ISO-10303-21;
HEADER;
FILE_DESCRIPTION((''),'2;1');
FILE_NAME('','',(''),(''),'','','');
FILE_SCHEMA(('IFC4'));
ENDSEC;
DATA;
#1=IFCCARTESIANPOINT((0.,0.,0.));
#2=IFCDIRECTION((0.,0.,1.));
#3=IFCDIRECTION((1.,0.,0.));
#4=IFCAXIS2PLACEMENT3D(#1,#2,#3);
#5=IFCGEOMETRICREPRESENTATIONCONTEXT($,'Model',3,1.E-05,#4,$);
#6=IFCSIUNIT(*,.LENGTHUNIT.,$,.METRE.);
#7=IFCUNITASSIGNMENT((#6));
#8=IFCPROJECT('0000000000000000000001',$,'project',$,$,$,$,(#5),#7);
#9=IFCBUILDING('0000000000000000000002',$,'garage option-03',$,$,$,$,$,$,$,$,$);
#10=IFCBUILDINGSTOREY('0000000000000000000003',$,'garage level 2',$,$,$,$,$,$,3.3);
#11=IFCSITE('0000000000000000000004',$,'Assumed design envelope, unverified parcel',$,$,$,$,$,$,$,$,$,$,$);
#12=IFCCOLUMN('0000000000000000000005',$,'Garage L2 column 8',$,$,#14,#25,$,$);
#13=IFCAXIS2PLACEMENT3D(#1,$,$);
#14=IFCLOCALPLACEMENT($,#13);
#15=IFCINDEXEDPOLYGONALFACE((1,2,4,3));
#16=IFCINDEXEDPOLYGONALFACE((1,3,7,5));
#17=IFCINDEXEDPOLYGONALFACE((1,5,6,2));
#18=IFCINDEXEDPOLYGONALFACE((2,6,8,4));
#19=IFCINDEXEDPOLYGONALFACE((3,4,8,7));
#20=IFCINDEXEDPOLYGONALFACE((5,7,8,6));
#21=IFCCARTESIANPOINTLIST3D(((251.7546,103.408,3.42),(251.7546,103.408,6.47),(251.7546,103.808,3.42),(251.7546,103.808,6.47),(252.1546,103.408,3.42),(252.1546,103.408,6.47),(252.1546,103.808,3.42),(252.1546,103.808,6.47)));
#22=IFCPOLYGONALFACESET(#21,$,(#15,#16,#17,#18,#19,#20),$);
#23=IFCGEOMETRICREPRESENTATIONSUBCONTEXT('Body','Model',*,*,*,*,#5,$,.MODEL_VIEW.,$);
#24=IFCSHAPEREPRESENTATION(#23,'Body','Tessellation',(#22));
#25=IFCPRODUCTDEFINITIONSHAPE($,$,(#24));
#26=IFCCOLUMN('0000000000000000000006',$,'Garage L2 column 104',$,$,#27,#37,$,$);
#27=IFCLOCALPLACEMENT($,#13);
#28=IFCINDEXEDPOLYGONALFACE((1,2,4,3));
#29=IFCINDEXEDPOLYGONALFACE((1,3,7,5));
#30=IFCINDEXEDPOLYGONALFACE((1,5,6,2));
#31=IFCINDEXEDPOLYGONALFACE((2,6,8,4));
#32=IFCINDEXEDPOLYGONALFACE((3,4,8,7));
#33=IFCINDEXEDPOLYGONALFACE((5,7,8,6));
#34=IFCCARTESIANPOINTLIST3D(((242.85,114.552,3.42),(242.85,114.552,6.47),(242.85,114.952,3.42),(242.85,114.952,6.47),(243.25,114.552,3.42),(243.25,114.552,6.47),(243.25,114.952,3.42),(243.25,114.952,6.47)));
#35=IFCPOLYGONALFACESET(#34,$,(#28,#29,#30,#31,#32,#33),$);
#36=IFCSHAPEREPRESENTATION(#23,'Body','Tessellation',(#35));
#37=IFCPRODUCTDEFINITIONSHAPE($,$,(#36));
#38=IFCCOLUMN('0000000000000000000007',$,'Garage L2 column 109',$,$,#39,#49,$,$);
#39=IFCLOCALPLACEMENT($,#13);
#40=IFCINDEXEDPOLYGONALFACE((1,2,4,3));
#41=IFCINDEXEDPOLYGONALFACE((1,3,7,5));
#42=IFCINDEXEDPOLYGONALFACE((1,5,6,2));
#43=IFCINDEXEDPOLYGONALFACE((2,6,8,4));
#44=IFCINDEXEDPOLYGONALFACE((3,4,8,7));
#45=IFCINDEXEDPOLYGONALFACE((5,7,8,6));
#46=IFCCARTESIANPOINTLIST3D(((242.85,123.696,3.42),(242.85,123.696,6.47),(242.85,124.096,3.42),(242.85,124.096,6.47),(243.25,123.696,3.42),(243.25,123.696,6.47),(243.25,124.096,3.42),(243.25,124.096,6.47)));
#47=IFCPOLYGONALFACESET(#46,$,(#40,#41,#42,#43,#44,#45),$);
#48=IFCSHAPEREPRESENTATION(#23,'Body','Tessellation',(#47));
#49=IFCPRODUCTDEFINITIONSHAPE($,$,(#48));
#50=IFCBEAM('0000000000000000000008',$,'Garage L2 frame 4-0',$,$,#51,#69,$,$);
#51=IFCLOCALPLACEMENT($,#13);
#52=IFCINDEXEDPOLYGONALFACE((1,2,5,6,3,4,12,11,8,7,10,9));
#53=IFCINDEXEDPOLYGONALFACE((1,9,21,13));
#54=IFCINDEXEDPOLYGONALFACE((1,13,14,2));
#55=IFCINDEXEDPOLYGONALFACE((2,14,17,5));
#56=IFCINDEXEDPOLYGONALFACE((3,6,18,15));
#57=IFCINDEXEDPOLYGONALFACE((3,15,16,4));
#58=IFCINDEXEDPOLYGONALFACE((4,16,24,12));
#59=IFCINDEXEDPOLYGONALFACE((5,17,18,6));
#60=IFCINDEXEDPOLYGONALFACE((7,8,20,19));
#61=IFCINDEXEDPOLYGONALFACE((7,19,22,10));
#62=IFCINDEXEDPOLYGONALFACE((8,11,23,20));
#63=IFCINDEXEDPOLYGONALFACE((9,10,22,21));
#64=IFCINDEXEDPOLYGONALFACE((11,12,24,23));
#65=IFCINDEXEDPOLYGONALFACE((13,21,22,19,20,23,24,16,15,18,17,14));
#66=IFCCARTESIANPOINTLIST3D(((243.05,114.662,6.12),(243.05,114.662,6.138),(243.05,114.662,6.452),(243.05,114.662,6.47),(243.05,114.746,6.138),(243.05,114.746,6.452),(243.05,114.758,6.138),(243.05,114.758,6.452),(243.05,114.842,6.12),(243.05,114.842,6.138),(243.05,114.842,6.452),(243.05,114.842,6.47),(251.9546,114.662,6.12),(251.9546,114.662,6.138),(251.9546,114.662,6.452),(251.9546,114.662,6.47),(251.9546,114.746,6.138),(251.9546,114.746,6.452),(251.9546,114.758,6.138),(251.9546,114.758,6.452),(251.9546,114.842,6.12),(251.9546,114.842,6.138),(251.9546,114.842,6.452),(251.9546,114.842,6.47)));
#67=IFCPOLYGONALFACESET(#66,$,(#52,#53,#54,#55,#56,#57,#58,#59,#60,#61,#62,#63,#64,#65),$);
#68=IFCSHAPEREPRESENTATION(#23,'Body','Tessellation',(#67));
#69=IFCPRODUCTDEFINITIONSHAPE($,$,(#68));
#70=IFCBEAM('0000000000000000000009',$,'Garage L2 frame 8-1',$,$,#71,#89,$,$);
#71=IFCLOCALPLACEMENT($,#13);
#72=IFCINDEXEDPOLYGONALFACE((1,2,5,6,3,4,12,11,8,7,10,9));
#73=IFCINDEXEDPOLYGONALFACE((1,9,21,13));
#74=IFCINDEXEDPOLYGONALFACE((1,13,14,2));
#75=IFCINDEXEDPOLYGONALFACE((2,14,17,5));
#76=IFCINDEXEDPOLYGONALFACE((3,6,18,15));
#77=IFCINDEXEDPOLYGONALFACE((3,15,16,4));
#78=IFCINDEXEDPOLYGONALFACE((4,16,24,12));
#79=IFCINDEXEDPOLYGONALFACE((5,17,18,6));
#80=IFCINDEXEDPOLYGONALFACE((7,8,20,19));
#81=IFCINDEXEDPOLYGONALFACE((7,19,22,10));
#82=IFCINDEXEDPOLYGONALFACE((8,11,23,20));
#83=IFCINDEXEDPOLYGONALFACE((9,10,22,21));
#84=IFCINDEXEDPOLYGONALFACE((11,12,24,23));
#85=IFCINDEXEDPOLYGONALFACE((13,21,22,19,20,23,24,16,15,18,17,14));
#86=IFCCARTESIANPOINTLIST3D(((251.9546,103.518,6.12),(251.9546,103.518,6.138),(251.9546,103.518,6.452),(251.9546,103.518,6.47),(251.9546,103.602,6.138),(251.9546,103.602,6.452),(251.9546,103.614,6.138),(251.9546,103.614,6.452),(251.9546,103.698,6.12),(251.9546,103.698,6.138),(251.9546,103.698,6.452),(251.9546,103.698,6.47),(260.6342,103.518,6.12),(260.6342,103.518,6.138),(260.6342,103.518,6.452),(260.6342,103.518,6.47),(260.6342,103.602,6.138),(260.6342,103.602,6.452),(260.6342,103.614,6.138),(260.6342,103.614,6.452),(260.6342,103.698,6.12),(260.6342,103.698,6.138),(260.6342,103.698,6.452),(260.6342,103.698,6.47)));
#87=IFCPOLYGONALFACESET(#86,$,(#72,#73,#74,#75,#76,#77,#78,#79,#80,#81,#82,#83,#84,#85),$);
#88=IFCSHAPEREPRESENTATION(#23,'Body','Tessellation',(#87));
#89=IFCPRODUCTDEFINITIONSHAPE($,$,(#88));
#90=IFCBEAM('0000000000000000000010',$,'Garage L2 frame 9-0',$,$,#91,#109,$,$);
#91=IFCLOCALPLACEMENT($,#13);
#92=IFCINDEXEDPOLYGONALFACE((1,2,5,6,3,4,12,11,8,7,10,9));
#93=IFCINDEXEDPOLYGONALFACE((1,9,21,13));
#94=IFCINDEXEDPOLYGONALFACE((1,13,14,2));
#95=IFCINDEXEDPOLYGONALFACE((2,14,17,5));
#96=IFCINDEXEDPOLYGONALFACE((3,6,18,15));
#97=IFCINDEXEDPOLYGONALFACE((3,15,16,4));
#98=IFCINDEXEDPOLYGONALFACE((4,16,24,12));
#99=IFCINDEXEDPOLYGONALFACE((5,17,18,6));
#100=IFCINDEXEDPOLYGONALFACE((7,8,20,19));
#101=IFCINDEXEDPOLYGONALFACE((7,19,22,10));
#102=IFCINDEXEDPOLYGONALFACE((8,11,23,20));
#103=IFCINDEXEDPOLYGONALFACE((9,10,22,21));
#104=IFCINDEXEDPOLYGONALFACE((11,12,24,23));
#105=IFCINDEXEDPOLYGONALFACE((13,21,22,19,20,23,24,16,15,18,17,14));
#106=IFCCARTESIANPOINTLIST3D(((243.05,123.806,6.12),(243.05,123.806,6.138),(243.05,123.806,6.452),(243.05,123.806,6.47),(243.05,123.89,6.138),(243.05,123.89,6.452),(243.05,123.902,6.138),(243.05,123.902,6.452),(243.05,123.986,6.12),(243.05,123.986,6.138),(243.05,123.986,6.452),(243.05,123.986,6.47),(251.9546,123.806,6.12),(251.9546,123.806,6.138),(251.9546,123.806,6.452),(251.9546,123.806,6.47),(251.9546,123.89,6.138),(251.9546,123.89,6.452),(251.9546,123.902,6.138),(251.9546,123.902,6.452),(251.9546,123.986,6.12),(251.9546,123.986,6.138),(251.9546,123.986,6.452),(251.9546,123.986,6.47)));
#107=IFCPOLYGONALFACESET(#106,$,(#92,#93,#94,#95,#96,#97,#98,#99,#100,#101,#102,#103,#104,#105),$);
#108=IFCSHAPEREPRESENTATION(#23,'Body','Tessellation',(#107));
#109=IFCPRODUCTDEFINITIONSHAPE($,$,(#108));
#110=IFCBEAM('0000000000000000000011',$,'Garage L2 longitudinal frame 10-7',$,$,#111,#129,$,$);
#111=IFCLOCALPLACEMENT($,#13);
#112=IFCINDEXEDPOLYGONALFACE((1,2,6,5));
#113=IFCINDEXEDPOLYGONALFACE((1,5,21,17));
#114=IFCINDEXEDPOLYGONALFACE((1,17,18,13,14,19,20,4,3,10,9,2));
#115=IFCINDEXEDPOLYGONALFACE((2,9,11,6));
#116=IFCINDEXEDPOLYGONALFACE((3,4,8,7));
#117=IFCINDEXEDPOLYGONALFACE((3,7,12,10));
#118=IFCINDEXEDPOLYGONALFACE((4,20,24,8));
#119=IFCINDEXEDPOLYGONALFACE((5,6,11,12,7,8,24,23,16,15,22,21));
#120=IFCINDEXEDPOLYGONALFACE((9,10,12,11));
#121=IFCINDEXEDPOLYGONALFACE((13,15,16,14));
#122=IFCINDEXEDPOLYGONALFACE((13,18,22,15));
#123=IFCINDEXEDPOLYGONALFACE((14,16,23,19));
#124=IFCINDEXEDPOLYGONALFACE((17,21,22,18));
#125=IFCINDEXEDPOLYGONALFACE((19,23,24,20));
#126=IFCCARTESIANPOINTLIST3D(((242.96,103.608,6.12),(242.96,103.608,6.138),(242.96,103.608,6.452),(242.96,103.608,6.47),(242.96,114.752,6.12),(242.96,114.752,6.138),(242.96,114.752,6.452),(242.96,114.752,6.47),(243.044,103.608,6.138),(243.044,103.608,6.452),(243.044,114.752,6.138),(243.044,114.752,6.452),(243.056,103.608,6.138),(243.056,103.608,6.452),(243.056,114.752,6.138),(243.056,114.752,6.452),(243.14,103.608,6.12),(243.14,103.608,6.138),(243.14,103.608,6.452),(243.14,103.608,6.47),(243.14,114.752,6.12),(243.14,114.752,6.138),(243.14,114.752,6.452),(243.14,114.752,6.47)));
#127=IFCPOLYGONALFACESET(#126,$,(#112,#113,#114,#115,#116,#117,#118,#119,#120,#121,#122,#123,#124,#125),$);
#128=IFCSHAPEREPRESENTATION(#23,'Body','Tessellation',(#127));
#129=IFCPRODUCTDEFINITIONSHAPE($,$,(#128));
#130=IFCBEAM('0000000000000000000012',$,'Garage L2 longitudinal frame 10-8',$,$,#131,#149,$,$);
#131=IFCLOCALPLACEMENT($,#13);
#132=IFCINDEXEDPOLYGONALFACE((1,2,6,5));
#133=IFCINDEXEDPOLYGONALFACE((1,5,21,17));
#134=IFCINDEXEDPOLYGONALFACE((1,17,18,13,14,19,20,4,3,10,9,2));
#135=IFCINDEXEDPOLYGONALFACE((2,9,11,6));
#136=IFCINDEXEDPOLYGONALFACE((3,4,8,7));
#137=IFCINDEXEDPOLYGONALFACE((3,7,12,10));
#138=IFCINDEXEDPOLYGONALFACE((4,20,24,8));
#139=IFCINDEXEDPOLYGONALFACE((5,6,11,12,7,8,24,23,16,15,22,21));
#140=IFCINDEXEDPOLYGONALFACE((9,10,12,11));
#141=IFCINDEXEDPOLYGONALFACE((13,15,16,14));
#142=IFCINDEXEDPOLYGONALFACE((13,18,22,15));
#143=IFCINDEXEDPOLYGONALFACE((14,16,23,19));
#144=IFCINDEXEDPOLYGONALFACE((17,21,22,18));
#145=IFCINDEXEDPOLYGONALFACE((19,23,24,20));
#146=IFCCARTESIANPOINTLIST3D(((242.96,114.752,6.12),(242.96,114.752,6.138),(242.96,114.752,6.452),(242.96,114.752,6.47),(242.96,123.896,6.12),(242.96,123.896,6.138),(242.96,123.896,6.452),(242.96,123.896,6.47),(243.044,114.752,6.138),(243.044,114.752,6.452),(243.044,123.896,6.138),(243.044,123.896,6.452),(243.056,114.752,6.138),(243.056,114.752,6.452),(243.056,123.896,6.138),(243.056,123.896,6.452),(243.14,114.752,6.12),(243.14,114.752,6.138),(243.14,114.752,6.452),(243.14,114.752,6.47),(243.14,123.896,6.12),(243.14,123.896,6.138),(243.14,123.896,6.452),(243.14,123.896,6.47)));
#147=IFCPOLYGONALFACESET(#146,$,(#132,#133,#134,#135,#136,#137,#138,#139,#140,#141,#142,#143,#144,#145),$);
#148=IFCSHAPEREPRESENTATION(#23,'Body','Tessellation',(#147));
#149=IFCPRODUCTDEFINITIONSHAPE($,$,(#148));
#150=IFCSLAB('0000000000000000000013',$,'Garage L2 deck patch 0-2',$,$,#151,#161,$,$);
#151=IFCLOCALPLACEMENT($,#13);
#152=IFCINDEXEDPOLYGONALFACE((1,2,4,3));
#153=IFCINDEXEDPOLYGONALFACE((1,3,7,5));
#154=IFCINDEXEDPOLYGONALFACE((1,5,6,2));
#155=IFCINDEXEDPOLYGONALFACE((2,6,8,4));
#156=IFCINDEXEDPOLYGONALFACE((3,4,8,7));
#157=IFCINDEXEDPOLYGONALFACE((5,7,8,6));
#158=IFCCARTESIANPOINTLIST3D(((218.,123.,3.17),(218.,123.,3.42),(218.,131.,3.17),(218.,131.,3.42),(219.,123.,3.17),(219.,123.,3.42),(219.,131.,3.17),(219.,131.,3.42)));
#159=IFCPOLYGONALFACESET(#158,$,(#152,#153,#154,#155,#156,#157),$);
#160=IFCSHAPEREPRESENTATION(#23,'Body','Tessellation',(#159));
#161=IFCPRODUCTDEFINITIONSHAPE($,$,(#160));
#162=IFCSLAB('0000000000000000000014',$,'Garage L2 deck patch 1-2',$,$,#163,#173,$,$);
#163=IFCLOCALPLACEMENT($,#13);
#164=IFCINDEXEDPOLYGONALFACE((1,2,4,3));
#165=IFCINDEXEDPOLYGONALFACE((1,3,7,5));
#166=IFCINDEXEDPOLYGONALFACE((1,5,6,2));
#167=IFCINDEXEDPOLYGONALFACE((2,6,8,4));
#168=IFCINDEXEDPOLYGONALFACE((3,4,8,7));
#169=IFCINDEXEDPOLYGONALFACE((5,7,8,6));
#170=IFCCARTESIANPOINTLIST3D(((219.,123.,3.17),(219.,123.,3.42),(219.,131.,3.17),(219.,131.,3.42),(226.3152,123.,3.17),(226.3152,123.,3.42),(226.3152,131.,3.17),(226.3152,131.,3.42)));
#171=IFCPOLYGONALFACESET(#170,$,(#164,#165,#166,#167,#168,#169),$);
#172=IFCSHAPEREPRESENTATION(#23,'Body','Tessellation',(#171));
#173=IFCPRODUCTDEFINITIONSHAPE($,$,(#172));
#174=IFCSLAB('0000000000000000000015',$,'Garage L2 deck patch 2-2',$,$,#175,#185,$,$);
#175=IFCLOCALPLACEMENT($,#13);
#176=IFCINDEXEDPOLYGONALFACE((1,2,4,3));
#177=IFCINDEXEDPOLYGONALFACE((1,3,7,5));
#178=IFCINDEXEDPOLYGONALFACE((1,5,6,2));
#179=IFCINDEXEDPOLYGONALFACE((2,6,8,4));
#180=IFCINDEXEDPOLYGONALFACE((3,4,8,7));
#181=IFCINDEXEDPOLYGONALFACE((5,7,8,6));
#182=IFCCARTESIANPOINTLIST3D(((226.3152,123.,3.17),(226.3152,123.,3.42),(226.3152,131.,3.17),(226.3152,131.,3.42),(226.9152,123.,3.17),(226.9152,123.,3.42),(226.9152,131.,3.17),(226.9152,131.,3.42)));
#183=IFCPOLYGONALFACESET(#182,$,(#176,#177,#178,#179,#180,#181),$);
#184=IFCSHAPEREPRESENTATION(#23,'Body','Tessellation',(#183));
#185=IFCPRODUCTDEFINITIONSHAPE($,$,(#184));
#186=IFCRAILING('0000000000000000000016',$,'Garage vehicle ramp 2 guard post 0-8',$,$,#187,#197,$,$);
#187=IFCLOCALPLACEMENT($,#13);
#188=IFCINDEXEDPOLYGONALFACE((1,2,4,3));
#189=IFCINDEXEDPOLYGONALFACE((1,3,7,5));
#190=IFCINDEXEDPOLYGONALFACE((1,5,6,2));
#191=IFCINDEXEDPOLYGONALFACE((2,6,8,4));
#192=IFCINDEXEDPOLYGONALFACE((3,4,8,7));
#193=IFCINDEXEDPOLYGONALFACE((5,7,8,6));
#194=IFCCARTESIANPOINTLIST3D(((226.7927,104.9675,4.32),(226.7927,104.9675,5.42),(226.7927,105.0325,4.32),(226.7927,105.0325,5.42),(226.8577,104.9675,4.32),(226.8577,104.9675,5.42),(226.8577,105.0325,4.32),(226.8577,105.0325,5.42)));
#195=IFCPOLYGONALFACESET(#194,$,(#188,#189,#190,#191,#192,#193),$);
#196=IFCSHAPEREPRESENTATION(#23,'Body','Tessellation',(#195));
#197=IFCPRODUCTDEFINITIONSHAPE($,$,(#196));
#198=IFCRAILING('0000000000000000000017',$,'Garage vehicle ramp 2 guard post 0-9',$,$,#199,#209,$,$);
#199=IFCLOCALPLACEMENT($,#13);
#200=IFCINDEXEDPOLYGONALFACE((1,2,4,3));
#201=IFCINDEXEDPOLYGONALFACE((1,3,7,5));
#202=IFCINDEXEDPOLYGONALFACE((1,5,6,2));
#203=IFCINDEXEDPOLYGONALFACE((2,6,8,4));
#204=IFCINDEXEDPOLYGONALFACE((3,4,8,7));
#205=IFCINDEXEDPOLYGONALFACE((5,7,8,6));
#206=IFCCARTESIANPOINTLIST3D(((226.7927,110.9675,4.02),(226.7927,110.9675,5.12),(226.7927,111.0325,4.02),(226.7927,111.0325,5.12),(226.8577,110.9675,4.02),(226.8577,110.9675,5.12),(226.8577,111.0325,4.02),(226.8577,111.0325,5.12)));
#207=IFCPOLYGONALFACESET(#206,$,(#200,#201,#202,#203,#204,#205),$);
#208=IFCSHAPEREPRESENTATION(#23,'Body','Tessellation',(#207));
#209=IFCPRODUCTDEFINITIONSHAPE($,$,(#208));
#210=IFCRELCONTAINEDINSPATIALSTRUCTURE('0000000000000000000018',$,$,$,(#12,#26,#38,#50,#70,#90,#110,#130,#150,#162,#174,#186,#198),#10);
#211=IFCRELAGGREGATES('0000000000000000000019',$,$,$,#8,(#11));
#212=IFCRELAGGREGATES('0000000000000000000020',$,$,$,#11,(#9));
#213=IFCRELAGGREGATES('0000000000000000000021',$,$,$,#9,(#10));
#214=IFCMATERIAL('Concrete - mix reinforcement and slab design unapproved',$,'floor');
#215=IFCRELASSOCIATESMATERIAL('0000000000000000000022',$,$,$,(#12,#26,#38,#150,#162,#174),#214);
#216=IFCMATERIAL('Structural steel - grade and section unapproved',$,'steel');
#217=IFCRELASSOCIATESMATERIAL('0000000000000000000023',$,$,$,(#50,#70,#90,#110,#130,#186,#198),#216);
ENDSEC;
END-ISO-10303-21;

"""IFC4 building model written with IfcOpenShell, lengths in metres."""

from ifc_helpers import new_model, si_unit, frame, origin_with_axes, place, context, subcontext, project, spatial, rectangle, i_section, extrude, material, element, save


model = new_model("IFC4")

# Units and contexts
model_context = context("Model", 3, precision=1e-05, world=origin_with_axes())
body_context = subcontext(model_context, "Body", "Model", "MODEL_VIEW")
ifc_project = project(units=[si_unit("LENGTHUNIT", "METRE")], contexts=[model_context])

# Site, building, storey
site = spatial("IfcSite", under=ifc_project, Name="Assumed design envelope, unverified parcel")
building = spatial("IfcBuilding", under=site, Name="garage option-03")
storey = spatial("IfcBuildingStorey", under=building, Name="garage level 2", Elevation=3.3)

# Columns
ifc_material_1 = material(Name="Concrete - mix reinforcement and slab design unapproved", Category="floor")
for number, where, z_axis, x_axis, name in (
    (1, (251.9546, 103.608, 3.42), (0.0, 0.0, 1.0), (1.0, 0.0, 0.0), "Garage L2 column 8"),
    (2, (243.05, 114.752, 3.42), (0.0, 0.0, 1.0), (1.0, 0.0, 0.0), "Garage L2 column 104"),
    (3, (243.05, 123.896, 3.42), (0.0, 0.0, 1.0), (1.0, 0.0, 0.0), "Garage L2 column 109"),
):
    element("IfcColumn", number, at=place(None, frame(where, z_axis=z_axis, x_axis=x_axis)), inside=storey, material=ifc_material_1, Name=name, context=body_context, shape_type="SweptSolid", body=[
        extrude(rectangle(XDim=0.4, YDim=0.4), origin_with_axes(), (0.0, 0.0, 1.0), 3.05),
    ])

# Beams
ifc_material_2 = material(Name="Structural steel - grade and section unapproved", Category="steel")
beam_1_placement = place(None, frame((243.05, 114.752, 6.295), z_axis=(1.0, 0.0, 0.0), x_axis=(0.0, 1.0, 0.0)))
element("IfcBeam", 4, at=beam_1_placement, inside=storey, material=ifc_material_2, Name="Garage L2 frame 4-0", context=body_context, shape_type="SweptSolid", body=[
    extrude(i_section(OverallWidth=0.18, OverallDepth=0.35, WebThickness=0.012, FlangeThickness=0.018, FilletRadius=0.0), origin_with_axes(), (0.0, 0.0, 1.0), 8.9046),
])
beam_2_placement = place(None, frame((251.9546, 103.608, 6.295), z_axis=(1.0, 0.0, 0.0), x_axis=(0.0, 1.0, 0.0)))
element("IfcBeam", 5, at=beam_2_placement, inside=storey, material=ifc_material_2, Name="Garage L2 frame 8-1", context=body_context, shape_type="SweptSolid", body=[
    extrude(i_section(OverallWidth=0.18, OverallDepth=0.35, WebThickness=0.012, FlangeThickness=0.018, FilletRadius=0.0), origin_with_axes(), (0.0, 0.0, 1.0), 8.6796),
])
beam_3_placement = place(None, frame((243.05, 123.896, 6.295), z_axis=(1.0, 0.0, 0.0), x_axis=(0.0, 1.0, 0.0)))
element("IfcBeam", 6, at=beam_3_placement, inside=storey, material=ifc_material_2, Name="Garage L2 frame 9-0", context=body_context, shape_type="SweptSolid", body=[
    extrude(i_section(OverallWidth=0.18, OverallDepth=0.35, WebThickness=0.012, FlangeThickness=0.018, FilletRadius=0.0), origin_with_axes(), (0.0, 0.0, 1.0), 8.9046),
])
beam_4_placement = place(None, frame((243.05, 103.608, 6.295), z_axis=(0.0, 1.0, 0.0), x_axis=(-1.0, 0.0, 0.0)))
element("IfcBeam", 7, at=beam_4_placement, inside=storey, material=ifc_material_2, Name="Garage L2 longitudinal frame 10-7", context=body_context, shape_type="SweptSolid", body=[
    extrude(i_section(OverallWidth=0.18, OverallDepth=0.35, WebThickness=0.012, FlangeThickness=0.018, FilletRadius=0.0), origin_with_axes(), (0.0, 0.0, 1.0), 11.144),
])
beam_5_placement = place(None, frame((243.05, 114.752, 6.295), z_axis=(0.0, 1.0, 0.0), x_axis=(-1.0, 0.0, 0.0)))
element("IfcBeam", 8, at=beam_5_placement, inside=storey, material=ifc_material_2, Name="Garage L2 longitudinal frame 10-8", context=body_context, shape_type="SweptSolid", body=[
    extrude(i_section(OverallWidth=0.18, OverallDepth=0.35, WebThickness=0.012, FlangeThickness=0.018, FilletRadius=0.0), origin_with_axes(), (0.0, 0.0, 1.0), 9.144),
])

# Slabs
slab_1_placement = place(None, frame((218.5, 127.0, 3.17), z_axis=(0.0, 0.0, 1.0), x_axis=(1.0, 0.0, 0.0)))
element("IfcSlab", 9, at=slab_1_placement, inside=storey, material=ifc_material_1, Name="Garage L2 deck patch 0-2", context=body_context, shape_type="SweptSolid", body=[
    extrude(rectangle(XDim=1.0, YDim=8.0), origin_with_axes(), (0.0, 0.0, 1.0), 0.25),
])
slab_2_placement = place(None, frame((222.6576, 127.0, 3.17), z_axis=(0.0, 0.0, 1.0), x_axis=(1.0, 0.0, 0.0)))
element("IfcSlab", 10, at=slab_2_placement, inside=storey, material=ifc_material_1, Name="Garage L2 deck patch 1-2", context=body_context, shape_type="SweptSolid", body=[
    extrude(rectangle(XDim=7.3152, YDim=8.0), origin_with_axes(), (0.0, 0.0, 1.0), 0.25),
])
slab_3_placement = place(None, frame((226.6152, 127.0, 3.17), z_axis=(0.0, 0.0, 1.0), x_axis=(1.0, 0.0, 0.0)))
element("IfcSlab", 11, at=slab_3_placement, inside=storey, material=ifc_material_1, Name="Garage L2 deck patch 2-2", context=body_context, shape_type="SweptSolid", body=[
    extrude(rectangle(XDim=0.6, YDim=8.0), origin_with_axes(), (0.0, 0.0, 1.0), 0.25),
])

# Railings
for number, where, z_axis, x_axis, name in (
    (12, (226.8252, 105.0, 4.32), (0.0, 0.0, 1.0), (-1.0, 0.0, 0.0), "Garage vehicle ramp 2 guard post 0-8"),
    (13, (226.8252, 111.0, 4.02), (0.0, 0.0, 1.0), (-1.0, 0.0, 0.0), "Garage vehicle ramp 2 guard post 0-9"),
):
    element("IfcRailing", number, at=place(None, frame(where, z_axis=z_axis, x_axis=x_axis)), inside=storey, material=ifc_material_2, Name=name, context=body_context, shape_type="SweptSolid", body=[
        extrude(rectangle(XDim=0.065, YDim=0.065), origin_with_axes(), (0.0, 0.0, 1.0), 1.1),
    ])

save(model, "model.ifc")
